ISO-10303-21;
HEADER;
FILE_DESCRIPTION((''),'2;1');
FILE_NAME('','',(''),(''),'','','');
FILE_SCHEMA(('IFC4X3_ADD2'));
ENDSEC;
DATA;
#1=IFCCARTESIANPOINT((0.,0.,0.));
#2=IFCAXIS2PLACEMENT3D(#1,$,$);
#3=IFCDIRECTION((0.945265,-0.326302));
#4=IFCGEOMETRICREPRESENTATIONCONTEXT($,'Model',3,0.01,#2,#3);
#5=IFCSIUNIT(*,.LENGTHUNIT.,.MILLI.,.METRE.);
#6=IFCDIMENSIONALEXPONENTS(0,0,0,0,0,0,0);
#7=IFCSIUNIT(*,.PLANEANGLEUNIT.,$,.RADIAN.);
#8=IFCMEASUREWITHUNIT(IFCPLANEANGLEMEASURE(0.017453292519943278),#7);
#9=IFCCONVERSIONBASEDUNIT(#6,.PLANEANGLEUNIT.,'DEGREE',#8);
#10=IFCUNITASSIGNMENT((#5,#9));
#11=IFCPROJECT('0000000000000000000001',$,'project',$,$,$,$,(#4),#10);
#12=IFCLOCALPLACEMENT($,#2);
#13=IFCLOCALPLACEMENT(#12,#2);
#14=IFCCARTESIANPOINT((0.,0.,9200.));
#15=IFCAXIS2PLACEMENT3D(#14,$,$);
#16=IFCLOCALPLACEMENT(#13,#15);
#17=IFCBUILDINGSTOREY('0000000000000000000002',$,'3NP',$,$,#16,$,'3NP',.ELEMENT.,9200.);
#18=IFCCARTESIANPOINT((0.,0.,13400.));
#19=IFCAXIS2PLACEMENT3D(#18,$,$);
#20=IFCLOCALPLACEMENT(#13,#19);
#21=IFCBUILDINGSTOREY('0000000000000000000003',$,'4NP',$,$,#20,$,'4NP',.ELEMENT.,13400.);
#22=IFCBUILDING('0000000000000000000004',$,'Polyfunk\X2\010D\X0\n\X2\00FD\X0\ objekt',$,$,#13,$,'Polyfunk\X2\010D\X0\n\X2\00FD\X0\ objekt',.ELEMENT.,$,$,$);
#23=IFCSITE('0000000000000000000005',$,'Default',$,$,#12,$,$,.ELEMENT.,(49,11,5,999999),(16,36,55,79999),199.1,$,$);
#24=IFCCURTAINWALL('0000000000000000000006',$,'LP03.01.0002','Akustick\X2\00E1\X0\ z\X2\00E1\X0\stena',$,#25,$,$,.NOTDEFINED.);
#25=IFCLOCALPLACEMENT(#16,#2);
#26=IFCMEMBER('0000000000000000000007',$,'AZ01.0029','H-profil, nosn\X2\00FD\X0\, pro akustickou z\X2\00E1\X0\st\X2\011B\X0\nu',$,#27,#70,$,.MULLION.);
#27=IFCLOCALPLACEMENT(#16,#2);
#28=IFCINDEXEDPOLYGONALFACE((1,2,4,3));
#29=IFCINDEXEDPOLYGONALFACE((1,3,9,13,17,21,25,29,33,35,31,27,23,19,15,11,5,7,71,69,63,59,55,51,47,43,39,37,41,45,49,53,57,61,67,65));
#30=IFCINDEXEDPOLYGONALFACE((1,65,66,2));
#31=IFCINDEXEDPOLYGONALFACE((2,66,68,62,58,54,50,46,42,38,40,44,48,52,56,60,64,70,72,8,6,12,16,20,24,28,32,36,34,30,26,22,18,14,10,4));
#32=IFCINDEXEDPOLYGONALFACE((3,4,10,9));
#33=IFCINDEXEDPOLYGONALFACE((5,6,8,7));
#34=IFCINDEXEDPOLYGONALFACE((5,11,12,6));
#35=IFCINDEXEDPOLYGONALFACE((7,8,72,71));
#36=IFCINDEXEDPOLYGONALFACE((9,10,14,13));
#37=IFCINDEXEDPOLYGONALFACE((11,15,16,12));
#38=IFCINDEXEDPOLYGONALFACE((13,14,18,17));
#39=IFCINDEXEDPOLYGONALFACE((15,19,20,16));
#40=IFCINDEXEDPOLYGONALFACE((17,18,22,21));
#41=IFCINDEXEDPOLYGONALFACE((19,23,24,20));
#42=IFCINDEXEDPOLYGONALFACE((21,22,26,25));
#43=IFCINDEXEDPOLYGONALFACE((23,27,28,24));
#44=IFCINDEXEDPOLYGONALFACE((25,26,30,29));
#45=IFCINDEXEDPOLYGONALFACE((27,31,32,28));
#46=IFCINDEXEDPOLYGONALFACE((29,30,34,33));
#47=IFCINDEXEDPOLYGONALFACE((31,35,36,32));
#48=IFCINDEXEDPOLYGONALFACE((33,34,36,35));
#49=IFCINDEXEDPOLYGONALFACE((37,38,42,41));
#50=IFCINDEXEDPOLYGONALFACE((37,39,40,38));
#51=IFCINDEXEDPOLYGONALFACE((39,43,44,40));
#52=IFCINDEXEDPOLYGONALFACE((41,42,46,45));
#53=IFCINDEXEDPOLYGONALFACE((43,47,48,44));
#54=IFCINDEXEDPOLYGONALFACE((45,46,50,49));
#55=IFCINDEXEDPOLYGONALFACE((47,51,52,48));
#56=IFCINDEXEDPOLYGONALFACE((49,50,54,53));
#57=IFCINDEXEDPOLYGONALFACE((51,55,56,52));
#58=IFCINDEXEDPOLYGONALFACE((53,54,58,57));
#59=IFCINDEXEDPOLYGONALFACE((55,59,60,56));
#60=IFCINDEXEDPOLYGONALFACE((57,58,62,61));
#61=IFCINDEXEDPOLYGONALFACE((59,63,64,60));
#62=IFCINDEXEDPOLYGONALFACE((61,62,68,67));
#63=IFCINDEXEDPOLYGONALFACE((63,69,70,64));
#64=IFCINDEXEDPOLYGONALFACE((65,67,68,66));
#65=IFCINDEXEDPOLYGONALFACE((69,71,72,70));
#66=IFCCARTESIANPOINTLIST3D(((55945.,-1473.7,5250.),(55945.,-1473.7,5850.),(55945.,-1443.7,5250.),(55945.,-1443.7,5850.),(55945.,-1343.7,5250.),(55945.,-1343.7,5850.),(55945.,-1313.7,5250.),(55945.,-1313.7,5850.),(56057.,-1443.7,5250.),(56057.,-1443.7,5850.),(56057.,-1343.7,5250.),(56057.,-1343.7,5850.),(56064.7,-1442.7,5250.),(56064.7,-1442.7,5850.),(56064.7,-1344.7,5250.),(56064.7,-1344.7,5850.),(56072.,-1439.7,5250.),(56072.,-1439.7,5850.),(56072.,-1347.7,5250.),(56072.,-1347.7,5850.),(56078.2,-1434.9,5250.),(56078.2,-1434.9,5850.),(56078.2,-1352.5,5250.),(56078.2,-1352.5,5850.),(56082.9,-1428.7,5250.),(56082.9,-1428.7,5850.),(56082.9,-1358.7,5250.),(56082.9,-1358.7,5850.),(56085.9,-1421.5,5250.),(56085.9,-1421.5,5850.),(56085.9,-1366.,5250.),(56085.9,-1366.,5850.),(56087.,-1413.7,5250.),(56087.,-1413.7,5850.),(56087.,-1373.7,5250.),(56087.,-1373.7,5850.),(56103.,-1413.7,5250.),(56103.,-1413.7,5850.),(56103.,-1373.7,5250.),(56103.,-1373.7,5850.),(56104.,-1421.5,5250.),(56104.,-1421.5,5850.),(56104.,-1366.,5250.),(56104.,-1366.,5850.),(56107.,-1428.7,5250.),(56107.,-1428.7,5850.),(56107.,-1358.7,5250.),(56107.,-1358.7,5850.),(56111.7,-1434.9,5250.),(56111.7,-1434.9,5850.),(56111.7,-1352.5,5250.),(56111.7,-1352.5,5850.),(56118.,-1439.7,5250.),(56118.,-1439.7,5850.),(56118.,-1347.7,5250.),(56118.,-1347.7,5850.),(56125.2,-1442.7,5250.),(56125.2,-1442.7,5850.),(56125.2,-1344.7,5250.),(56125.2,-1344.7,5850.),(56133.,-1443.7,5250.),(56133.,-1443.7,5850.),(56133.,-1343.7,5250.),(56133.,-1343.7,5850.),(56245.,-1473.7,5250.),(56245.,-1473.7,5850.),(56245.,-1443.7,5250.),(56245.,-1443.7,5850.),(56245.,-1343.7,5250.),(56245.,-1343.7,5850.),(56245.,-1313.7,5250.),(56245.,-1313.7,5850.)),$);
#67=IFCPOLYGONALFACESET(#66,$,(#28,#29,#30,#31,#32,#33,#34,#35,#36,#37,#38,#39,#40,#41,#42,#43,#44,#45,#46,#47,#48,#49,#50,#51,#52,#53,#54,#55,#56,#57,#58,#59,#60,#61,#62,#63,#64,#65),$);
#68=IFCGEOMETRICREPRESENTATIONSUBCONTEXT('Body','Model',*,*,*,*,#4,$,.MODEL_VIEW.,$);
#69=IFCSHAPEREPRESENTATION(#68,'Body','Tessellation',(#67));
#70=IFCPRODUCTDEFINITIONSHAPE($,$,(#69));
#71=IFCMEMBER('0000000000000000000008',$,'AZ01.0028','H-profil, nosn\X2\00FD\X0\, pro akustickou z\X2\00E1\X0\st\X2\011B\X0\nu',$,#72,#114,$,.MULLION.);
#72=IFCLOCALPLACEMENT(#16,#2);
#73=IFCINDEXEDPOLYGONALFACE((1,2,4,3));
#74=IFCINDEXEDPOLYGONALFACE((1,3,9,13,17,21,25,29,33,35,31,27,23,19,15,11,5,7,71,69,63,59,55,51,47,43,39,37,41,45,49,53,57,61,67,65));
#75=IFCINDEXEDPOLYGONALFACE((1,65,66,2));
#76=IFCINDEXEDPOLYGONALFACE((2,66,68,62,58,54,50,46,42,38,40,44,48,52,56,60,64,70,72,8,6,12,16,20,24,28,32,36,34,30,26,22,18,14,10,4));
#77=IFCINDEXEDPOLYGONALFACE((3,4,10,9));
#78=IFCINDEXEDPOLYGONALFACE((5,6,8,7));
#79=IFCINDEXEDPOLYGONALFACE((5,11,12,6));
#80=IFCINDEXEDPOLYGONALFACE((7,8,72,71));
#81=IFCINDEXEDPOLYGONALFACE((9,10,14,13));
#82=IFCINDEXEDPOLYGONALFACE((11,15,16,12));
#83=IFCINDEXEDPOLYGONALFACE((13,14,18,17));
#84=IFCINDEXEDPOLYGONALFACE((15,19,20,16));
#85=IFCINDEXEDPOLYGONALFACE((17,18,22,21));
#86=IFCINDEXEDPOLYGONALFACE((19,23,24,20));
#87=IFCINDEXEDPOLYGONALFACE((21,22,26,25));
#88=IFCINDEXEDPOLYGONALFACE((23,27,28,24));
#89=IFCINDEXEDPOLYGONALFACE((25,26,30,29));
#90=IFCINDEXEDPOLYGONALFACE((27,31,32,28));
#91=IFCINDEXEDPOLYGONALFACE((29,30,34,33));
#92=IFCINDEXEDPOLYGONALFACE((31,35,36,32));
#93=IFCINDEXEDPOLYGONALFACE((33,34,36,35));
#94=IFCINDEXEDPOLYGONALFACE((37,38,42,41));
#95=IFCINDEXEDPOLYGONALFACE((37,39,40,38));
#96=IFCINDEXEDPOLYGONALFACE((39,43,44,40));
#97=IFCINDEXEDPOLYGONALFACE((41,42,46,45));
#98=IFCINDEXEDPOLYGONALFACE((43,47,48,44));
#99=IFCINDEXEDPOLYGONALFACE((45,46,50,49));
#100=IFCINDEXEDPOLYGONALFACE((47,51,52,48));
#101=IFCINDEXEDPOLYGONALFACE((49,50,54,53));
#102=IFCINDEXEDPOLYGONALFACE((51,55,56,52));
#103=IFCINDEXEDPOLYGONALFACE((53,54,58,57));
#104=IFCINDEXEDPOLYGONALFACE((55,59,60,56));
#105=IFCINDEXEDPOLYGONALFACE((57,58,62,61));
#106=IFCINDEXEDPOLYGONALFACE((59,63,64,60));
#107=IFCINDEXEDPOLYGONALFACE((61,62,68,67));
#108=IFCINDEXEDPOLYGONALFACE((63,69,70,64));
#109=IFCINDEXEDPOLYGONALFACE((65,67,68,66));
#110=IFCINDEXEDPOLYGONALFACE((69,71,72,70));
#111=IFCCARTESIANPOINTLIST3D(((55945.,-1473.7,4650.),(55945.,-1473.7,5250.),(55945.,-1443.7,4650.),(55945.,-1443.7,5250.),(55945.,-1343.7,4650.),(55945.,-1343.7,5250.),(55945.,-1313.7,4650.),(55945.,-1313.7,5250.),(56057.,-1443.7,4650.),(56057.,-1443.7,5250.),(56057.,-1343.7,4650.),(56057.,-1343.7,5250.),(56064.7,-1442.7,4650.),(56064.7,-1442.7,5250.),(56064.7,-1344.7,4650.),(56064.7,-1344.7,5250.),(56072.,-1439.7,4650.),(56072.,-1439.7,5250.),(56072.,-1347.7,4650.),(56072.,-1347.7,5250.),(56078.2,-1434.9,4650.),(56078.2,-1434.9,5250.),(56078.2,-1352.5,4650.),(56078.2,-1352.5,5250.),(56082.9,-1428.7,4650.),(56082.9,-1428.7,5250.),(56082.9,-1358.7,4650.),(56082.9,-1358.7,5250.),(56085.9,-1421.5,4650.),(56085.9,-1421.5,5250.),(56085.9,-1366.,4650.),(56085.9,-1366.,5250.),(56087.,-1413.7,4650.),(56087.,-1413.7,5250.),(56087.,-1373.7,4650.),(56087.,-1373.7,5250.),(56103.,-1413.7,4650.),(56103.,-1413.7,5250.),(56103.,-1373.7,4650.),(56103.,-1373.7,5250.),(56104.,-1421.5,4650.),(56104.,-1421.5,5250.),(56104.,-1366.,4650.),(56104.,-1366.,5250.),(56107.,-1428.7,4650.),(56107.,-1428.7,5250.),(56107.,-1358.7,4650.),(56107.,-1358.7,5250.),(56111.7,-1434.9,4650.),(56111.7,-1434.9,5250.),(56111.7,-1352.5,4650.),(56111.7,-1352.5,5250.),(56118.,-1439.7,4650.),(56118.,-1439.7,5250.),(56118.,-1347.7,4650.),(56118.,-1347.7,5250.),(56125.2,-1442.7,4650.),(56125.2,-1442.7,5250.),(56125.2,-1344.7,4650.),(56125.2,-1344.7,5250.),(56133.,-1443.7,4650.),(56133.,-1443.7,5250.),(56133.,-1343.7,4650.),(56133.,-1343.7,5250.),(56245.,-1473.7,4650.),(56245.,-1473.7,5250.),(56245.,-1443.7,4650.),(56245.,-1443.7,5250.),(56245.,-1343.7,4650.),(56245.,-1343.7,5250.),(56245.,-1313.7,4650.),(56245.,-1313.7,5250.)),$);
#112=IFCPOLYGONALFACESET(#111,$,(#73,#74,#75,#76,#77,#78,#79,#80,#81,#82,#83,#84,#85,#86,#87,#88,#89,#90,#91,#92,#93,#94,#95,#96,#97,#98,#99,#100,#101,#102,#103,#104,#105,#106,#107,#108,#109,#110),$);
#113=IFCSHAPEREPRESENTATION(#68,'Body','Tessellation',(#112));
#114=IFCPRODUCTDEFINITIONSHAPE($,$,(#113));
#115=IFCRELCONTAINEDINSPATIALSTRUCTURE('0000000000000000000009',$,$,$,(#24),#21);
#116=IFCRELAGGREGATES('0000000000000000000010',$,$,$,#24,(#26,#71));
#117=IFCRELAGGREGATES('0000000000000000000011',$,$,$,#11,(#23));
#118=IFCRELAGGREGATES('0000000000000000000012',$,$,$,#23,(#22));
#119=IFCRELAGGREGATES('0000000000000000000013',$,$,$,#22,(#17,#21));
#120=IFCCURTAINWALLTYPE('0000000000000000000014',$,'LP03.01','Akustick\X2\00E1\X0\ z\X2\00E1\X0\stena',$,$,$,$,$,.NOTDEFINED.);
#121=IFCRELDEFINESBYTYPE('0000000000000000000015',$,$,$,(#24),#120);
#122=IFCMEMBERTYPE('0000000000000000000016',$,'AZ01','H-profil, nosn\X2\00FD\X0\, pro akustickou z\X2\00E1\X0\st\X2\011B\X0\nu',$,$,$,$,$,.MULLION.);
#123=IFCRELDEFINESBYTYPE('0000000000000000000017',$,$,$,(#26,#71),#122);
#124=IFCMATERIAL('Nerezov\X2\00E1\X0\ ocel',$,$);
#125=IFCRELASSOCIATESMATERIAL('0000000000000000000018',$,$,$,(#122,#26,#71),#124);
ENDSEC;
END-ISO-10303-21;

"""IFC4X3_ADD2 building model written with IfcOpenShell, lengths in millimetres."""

from ifc_helpers import new_model, entity, si_unit, converted_unit, direction, frame, frame_2d, origin, place, context, subcontext, project, spatial, polyline, circle_curve, parameter, trimmed, segment, composite_curve, outline, extrude, source, transform, mapped, material, material_profile, profile_set, profile_usage, type_object, element, aggregate, save


model = new_model("IFC4X3_ADD2")

# Units and contexts
model_context = context("Model", 3, precision=0.01, world=origin(), true_north=direction((0.945265, -0.326302)))
body_context = subcontext(model_context, "Body", "Model", "MODEL_VIEW")
ifc_project = project(units=[si_unit("LENGTHUNIT", "METRE", prefix="MILLI"), converted_unit("PLANEANGLEUNIT", "DEGREE", entity("IfcPlaneAngleMeasure", 0.017453292519943278), si_unit("PLANEANGLEUNIT", "RADIAN"), dimensions=[0, 0, 0, 0, 0, 0, 0])], contexts=[model_context])

# Site, building, storey
site_placement = place(None, origin())
site = spatial("IfcSite", under=ifc_project, at=site_placement, Name="Default", CompositionType="ELEMENT", RefLatitude=(49, 11, 5, 999999), RefLongitude=(16, 36, 55, 79999), RefElevation=199.1)
building_placement = place(site_placement, origin())
building = spatial("IfcBuilding", under=site, at=building_placement, Name="Polyfunkčný objekt", LongName="Polyfunkčný objekt", CompositionType="ELEMENT")
storey_1_placement = place(building_placement, frame((0.0, 0.0, 9200.0)))
storey_1 = spatial("IfcBuildingStorey", under=building, at=storey_1_placement, Name="3NP", LongName="3NP", CompositionType="ELEMENT", Elevation=9200.0)

# Shared definitions
storey_2_placement = place(building_placement, frame((0.0, 0.0, 13400.0)))
storey_2 = spatial("IfcBuildingStorey", under=building, at=storey_2_placement, Name="4NP", LongName="4NP", CompositionType="ELEMENT", Elevation=13400.0)

# Curtain wall, members
curtain_wall_type_1 = type_object("IfcCurtainWallType", Name="LP03.01", Description="Akustická zástena", PredefinedType="NOTDEFINED")
ifc_material_1 = material(Name="Nerezová ocel")
ifc_material_profile_1 = material_profile(ifc_material_1, outline(composite_curve([segment(polyline([(50.0, -150.0), (80.0, -150.0)]), True, "CONTINUOUS"), segment(polyline([(80.0, -150.0), (80.0, 150.0)]), True, "CONTINUOUS"), segment(polyline([(80.0, 150.0), (50.0, 150.0)]), True, "CONTINUOUS"), segment(polyline([(50.0, 150.0), (50.0, 38.0)]), True, "CONTINUOUS"), segment(trimmed(circle_curve(frame_2d((20.0, 38.0), x_axis=(0.0, 1.0)), 30.0), [parameter(180.0)], [parameter(270.0)], True, "PARAMETER"), False, "CONTINUOUS"), segment(polyline([(20.0, 8.0), (-20.0, 8.0)]), True, "CONTINUOUS"), segment(trimmed(circle_curve(frame_2d((-20.0, 38.0), x_axis=(0.0, 1.0)), 30.0), [parameter(90.0)], [parameter(180.0)], True, "PARAMETER"), False, "CONTINUOUS"), segment(polyline([(-50.0, 38.0), (-50.0, 150.0)]), True, "CONTINUOUS"), segment(polyline([(-50.0, 150.0), (-80.0, 150.0)]), True, "CONTINUOUS"), segment(polyline([(-80.0, 150.0), (-80.0, -150.0)]), True, "CONTINUOUS"), segment(polyline([(-80.0, -150.0), (-50.0, -150.0)]), True, "CONTINUOUS"), segment(polyline([(-50.0, -150.0), (-50.0, -38.0)]), True, "CONTINUOUS"), segment(trimmed(circle_curve(frame_2d((-20.0, -38.0), x_axis=(0.0, 1.0)), 30.0), [parameter(0.0)], [parameter(90.0)], True, "PARAMETER"), False, "CONTINUOUS"), segment(polyline([(-20.0, -8.0), (20.0, -8.0)]), True, "CONTINUOUS"), segment(trimmed(circle_curve(frame_2d((20.0, -38.0), x_axis=(0.0, 1.0)), 30.0), [parameter(270.0)], [parameter(0.0)], True, "PARAMETER"), False, "CONTINUOUS"), segment(polyline([(50.0, -38.0), (50.0, -150.0)]), True, "CONTINUOUS")], self_intersect=False)), Name="Profil zástena")
ifc_profile_set_1 = profile_set([ifc_material_profile_1], Name="Profil zástena")
ifc_profile_usage_1 = profile_usage(ifc_profile_set_1)
member_type_1 = type_object("IfcMemberType", Name="AZ01", Description="H-profil, nosný, pro akustickou zástěnu", PredefinedType="MULLION", material=ifc_profile_set_1)
curtain_wall_1_placement = place(storey_2_placement, frame((0.0, 0.0, -13400.0)))
curtain_wall_1 = element("IfcCurtainWall", 1, at=curtain_wall_1_placement, inside=storey_2, type_object=curtain_wall_type_1, Name="LP03.01.0002", Description="Akustická zástena", PredefinedType="NOTDEFINED")
shared_shape_1 = source(origin(), body_context, "Body", "SweptSolid", [
    extrude(outline(composite_curve([segment(polyline([(50.0, -150.0), (80.0, -150.0)]), True, "CONTINUOUS"), segment(polyline([(80.0, -150.0), (80.0, 150.0)]), True, "CONTINUOUS"), segment(polyline([(80.0, 150.0), (50.0, 150.0)]), True, "CONTINUOUS"), segment(polyline([(50.0, 150.0), (50.0, 38.0)]), True, "CONTINUOUS"), segment(trimmed(circle_curve(frame_2d((20.0, 38.0), x_axis=(0.0, 1.0)), 30.0), [parameter(180.0)], [parameter(270.0)], True, "PARAMETER"), False, "CONTINUOUS"), segment(polyline([(20.0, 8.0), (-20.0, 8.0)]), True, "CONTINUOUS"), segment(trimmed(circle_curve(frame_2d((-20.0, 38.0), x_axis=(0.0, 1.0)), 30.0), [parameter(90.0)], [parameter(180.0)], True, "PARAMETER"), False, "CONTINUOUS"), segment(polyline([(-50.0, 38.0), (-50.0, 150.0)]), True, "CONTINUOUS"), segment(polyline([(-50.0, 150.0), (-80.0, 150.0)]), True, "CONTINUOUS"), segment(polyline([(-80.0, 150.0), (-80.0, -150.0)]), True, "CONTINUOUS"), segment(polyline([(-80.0, -150.0), (-50.0, -150.0)]), True, "CONTINUOUS"), segment(polyline([(-50.0, -150.0), (-50.0, -38.0)]), True, "CONTINUOUS"), segment(trimmed(circle_curve(frame_2d((-20.0, -38.0), x_axis=(0.0, 1.0)), 30.0), [parameter(0.0)], [parameter(90.0)], True, "PARAMETER"), False, "CONTINUOUS"), segment(polyline([(-20.0, -8.0), (20.0, -8.0)]), True, "CONTINUOUS"), segment(trimmed(circle_curve(frame_2d((20.0, -38.0), x_axis=(0.0, 1.0)), 30.0), [parameter(270.0)], [parameter(0.0)], True, "PARAMETER"), False, "CONTINUOUS"), segment(polyline([(50.0, -38.0), (50.0, -150.0)]), True, "CONTINUOUS")], self_intersect=False)), frame((-150.0, 0.0, -600.0), z_axis=(0.0, 0.0, 1.0), x_axis=(0.0, -1.0, 0.0)), (0.0, 0.0, 1.0), 600.0),
])
member_1_placement = place(curtain_wall_1_placement, frame((56245.0, -1393.7, 14450.0), z_axis=(0.0, 0.0, -1.0), x_axis=(1.0, 0.0, 0.0)))
member_1 = element("IfcMember", 2, at=member_1_placement, type_object=member_type_1, material=ifc_profile_usage_1, Name="AZ01.0029", Description="H-profil, nosný, pro akustickou zástěnu", PredefinedType="MULLION", context=body_context, shape_type="MappedRepresentation", body=[
    mapped(shared_shape_1, transform((0.0, 0.0, 0.0), scale=1.0)),
])
member_2_placement = place(curtain_wall_1_placement, frame((56245.0, -1393.7, 13850.0), z_axis=(0.0, 0.0, -1.0), x_axis=(1.0, 0.0, 0.0)))
member_2 = element("IfcMember", 3, at=member_2_placement, type_object=member_type_1, material=ifc_profile_usage_1, Name="AZ01.0028", Description="H-profil, nosný, pro akustickou zástěnu", PredefinedType="MULLION", context=body_context, shape_type="MappedRepresentation", body=[
    mapped(shared_shape_1, transform((0.0, 0.0, 0.0), scale=1.0)),
])
aggregate(curtain_wall_1, [member_1, member_2])

save(model, "model.ifc")
